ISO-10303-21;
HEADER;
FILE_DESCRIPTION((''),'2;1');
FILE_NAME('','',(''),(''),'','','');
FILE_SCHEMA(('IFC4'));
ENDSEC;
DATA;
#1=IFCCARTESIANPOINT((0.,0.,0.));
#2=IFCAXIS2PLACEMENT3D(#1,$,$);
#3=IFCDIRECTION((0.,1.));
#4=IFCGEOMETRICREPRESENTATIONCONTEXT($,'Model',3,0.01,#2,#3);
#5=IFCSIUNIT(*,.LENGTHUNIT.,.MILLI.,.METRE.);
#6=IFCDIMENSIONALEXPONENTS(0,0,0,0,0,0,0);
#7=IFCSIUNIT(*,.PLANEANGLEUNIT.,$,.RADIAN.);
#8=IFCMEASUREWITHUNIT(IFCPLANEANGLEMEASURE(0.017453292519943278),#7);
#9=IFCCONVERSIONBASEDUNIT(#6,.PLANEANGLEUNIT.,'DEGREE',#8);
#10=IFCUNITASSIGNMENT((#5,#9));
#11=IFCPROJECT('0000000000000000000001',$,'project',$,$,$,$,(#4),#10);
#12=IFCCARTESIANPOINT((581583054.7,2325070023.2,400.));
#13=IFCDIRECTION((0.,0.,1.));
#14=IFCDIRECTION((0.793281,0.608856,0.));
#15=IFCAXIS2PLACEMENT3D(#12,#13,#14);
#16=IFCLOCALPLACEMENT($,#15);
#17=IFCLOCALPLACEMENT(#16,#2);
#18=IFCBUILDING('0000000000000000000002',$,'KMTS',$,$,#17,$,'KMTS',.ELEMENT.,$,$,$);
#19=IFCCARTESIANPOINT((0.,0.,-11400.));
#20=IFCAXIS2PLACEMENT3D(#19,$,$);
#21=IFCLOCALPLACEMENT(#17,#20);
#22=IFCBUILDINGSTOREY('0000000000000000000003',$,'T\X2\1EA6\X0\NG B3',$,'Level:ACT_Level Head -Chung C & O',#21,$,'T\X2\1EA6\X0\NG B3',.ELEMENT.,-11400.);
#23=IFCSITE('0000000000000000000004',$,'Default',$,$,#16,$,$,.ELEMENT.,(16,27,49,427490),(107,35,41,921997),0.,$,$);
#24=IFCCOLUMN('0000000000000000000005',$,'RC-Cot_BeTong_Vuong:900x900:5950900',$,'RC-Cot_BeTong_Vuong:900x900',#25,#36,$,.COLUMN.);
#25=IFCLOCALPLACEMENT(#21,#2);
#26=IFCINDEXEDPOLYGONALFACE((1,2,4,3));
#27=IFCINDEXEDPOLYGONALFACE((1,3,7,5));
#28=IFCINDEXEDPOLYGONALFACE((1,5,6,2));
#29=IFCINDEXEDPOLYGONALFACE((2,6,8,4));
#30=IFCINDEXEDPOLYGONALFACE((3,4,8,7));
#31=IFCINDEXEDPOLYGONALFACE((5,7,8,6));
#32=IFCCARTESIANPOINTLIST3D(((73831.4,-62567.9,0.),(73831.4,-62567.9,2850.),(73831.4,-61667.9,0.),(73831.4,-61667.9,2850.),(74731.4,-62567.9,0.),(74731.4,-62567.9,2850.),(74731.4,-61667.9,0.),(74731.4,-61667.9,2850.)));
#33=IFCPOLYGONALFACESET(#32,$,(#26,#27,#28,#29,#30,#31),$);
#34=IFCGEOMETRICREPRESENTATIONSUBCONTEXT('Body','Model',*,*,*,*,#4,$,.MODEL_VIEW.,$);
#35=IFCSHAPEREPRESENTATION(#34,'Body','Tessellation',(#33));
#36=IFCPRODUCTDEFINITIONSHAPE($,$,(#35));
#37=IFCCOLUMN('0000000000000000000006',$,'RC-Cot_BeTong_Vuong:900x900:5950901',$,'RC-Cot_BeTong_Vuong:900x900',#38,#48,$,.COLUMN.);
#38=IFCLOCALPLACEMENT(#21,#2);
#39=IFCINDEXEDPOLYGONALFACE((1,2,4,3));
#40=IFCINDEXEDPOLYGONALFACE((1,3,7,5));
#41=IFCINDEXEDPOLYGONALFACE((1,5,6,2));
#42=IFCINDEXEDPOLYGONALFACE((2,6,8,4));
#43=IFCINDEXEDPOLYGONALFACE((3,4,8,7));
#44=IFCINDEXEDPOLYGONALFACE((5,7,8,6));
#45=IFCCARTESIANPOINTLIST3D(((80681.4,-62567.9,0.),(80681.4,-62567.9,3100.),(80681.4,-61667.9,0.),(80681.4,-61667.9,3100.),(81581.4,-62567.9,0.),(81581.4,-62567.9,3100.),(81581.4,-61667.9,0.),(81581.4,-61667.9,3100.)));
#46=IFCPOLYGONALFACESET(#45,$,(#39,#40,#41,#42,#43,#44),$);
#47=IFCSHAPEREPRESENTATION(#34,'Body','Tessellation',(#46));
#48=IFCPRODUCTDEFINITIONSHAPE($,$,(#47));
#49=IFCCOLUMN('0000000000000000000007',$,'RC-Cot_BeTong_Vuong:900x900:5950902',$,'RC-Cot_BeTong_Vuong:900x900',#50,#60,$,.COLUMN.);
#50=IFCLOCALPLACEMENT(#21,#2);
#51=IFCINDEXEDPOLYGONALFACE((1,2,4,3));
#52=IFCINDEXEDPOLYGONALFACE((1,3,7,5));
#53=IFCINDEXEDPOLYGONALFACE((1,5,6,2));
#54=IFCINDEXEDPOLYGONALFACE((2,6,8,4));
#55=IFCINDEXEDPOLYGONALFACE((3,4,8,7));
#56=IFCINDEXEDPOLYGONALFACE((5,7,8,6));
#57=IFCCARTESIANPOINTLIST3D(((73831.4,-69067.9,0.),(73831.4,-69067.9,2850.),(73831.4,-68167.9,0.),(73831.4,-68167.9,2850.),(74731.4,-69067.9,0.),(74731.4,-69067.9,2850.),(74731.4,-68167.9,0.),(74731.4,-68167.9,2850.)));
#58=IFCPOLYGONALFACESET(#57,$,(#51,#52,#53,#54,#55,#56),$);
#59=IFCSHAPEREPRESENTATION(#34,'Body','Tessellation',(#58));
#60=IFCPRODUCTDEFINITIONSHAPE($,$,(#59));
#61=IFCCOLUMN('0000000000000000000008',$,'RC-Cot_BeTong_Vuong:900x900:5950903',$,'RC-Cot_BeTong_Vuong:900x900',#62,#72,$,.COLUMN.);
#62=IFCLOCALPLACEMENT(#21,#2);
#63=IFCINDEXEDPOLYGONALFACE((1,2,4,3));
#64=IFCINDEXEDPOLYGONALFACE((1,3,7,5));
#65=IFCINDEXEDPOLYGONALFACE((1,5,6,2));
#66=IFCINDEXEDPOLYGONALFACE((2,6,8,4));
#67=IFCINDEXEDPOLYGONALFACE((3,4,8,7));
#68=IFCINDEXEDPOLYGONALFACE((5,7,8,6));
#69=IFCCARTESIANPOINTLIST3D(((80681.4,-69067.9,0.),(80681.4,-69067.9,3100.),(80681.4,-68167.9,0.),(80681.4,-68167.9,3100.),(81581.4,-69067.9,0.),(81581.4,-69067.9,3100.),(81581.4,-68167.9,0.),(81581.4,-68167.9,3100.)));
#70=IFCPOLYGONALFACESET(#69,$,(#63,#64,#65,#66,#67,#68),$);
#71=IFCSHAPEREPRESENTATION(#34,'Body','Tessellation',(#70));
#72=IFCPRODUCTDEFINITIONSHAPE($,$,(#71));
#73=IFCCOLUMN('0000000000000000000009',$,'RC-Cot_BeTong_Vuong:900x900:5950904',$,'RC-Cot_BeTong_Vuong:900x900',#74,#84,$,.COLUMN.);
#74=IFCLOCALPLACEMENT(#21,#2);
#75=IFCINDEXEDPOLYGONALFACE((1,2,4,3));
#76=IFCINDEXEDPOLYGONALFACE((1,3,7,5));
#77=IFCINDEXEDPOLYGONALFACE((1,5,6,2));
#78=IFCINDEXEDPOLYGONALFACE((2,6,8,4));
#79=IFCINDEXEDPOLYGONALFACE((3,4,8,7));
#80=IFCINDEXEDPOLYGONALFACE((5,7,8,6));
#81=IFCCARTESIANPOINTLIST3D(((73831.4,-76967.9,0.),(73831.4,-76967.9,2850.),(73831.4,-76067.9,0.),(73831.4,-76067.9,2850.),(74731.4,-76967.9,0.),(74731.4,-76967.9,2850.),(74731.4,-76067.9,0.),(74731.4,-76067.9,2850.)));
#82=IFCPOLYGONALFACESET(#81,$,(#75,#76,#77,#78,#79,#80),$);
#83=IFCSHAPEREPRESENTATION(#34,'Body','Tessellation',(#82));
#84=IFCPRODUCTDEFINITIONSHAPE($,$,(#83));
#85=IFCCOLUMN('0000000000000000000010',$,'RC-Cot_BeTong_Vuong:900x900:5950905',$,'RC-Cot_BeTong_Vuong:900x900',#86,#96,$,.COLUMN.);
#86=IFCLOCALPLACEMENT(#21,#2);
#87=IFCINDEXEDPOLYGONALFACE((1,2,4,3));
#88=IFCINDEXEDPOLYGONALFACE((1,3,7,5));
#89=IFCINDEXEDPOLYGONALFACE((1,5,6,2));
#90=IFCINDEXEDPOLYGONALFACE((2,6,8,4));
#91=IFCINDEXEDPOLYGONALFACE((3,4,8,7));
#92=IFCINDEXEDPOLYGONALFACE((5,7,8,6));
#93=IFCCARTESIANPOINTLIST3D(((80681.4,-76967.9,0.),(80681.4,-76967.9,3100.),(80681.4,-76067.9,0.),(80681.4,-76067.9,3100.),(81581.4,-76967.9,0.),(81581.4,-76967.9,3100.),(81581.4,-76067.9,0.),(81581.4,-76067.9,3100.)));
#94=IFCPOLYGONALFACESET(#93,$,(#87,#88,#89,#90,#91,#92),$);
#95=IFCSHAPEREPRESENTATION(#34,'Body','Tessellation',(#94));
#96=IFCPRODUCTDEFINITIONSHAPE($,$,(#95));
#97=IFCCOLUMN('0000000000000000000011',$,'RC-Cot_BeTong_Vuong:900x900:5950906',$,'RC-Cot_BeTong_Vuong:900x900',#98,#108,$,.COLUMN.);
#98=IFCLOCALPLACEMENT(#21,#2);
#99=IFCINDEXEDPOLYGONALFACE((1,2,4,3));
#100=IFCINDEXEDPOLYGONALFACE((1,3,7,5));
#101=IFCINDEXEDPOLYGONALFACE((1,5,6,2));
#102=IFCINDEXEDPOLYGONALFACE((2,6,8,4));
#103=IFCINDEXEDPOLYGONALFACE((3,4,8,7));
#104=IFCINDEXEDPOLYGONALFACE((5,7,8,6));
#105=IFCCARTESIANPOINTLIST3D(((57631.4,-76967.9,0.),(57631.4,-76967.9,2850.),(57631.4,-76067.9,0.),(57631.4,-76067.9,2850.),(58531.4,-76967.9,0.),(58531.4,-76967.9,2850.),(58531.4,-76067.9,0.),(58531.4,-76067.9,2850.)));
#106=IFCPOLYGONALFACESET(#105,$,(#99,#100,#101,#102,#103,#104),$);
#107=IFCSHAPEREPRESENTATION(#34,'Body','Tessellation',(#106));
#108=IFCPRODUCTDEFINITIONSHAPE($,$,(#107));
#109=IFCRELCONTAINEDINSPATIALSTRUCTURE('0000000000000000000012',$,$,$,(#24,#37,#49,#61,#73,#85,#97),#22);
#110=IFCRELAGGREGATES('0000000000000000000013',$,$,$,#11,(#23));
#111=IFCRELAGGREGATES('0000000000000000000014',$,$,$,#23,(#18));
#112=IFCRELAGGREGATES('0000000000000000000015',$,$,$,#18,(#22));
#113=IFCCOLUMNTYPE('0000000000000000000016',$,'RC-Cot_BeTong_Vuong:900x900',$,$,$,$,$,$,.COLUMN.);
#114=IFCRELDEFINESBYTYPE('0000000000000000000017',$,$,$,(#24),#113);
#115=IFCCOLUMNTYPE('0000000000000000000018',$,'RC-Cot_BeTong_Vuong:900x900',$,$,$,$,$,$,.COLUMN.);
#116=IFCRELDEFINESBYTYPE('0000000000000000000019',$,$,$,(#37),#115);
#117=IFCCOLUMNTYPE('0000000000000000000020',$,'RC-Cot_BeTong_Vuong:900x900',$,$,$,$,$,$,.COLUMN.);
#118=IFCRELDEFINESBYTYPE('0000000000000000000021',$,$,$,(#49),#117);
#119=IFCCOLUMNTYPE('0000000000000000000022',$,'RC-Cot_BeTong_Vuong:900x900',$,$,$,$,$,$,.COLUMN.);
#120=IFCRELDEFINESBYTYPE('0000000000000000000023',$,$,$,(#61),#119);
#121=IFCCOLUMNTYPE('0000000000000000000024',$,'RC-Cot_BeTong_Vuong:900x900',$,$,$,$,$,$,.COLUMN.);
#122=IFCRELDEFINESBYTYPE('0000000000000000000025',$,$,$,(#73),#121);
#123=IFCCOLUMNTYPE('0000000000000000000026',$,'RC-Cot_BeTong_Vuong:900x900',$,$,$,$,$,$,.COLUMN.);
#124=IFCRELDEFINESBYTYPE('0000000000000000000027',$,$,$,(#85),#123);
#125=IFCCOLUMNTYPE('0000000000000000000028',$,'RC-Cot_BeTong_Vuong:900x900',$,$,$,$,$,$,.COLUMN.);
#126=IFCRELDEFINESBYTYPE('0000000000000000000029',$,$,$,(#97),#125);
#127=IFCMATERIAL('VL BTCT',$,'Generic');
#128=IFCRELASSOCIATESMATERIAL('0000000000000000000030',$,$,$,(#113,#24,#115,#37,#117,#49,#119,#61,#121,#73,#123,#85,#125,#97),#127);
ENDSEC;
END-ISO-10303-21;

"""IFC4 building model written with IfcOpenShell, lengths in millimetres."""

from ifc_helpers import new_model, entity, si_unit, converted_unit, direction, frame, origin, place, context, subcontext, project, spatial, indexed_curve, outline, extrude, source, transform, mapped, material, type_object, type_shapes, element, save


model = new_model("IFC4")

# Units and contexts
model_context = context("Model", 3, precision=0.01, world=origin(), true_north=direction((0.0, 1.0)))
body_context = subcontext(model_context, "Body", "Model", "MODEL_VIEW")
ifc_project = project(units=[si_unit("LENGTHUNIT", "METRE", prefix="MILLI"), converted_unit("PLANEANGLEUNIT", "DEGREE", entity("IfcPlaneAngleMeasure", 0.017453292519943278), si_unit("PLANEANGLEUNIT", "RADIAN"), dimensions=[0, 0, 0, 0, 0, 0, 0])], contexts=[model_context])

# Site, building, storey
site_placement = place(None, frame((581583054.7, 2325070023.2, 400.0), z_axis=(0.0, 0.0, 1.0), x_axis=(0.793281, 0.608856, 0.0)))
site = spatial("IfcSite", under=ifc_project, at=site_placement, Name="Default", CompositionType="ELEMENT", RefLatitude=(16, 27, 49, 427490), RefLongitude=(107, 35, 41, 921997), RefElevation=0.0)
building_placement = place(site_placement, origin())
building = spatial("IfcBuilding", under=site, at=building_placement, Name="KMTS", LongName="KMTS", CompositionType="ELEMENT")
storey_placement = place(building_placement, frame((0.0, 0.0, -11400.0)))
storey = spatial("IfcBuildingStorey", under=building, at=storey_placement, Name="TẦNG B3", ObjectType="Level:ACT_Level Head -Chung C & O", LongName="TẦNG B3", CompositionType="ELEMENT", Elevation=-11400.0)

# Columns
ifc_material = material(Name="VL BTCT", Category="Generic")
column_type_1 = type_object("IfcColumnType", Name="RC-Cot_BeTong_Vuong:900x900", PredefinedType="COLUMN", material=ifc_material)
shared_shape_1 = source(origin(), body_context, "Body", "SweptSolid", [
    extrude(outline(indexed_curve([(-450.0, -450.0), (450.0, -450.0), (450.0, 450.0), (-450.0, 450.0), (-450.0, -450.0)], self_intersect=False)), frame((74281.4, -62117.9, -11400.0), z_axis=(0.0, 0.0, 1.0), x_axis=(-1.0, 0.0, 0.0)), (0.0, 0.0, 1.0), 2850.0),
])
type_shapes(column_type_1, [shared_shape_1])
column_1_placement = place(storey_placement, frame((0.0, 0.0, 11400.0)))
element("IfcColumn", 1, at=column_1_placement, inside=storey, type_object=column_type_1, material=ifc_material, Name="RC-Cot_BeTong_Vuong:900x900:5950900", ObjectType="RC-Cot_BeTong_Vuong:900x900", PredefinedType="COLUMN", context=body_context, shape_type="MappedRepresentation", body=[
    mapped(shared_shape_1, transform((0.0, 0.0, 0.0), scale=1.0)),
])
column_type_2 = type_object("IfcColumnType", Name="RC-Cot_BeTong_Vuong:900x900", PredefinedType="COLUMN", material=ifc_material)
shared_shape_2 = source(origin(), body_context, "Body", "SweptSolid", [
    extrude(outline(indexed_curve([(-450.0, -450.0), (450.0, -450.0), (450.0, 450.0), (-450.0, 450.0), (-450.0, -450.0)], self_intersect=False)), frame((81131.4, -62117.9, -11400.0), z_axis=(0.0, 0.0, 1.0), x_axis=(-1.0, 0.0, 0.0)), (0.0, 0.0, 1.0), 3100.0),
])
type_shapes(column_type_2, [shared_shape_2])
column_2_placement = place(storey_placement, frame((0.0, 0.0, 11400.0)))
element("IfcColumn", 2, at=column_2_placement, inside=storey, type_object=column_type_2, material=ifc_material, Name="RC-Cot_BeTong_Vuong:900x900:5950901", ObjectType="RC-Cot_BeTong_Vuong:900x900", PredefinedType="COLUMN", context=body_context, shape_type="MappedRepresentation", body=[
    mapped(shared_shape_2, transform((0.0, 0.0, 0.0), scale=1.0)),
])
column_type_3 = type_object("IfcColumnType", Name="RC-Cot_BeTong_Vuong:900x900", PredefinedType="COLUMN", material=ifc_material)
shared_shape_3 = source(origin(), body_context, "Body", "SweptSolid", [
    extrude(outline(indexed_curve([(-450.0, -450.0), (450.0, -450.0), (450.0, 450.0), (-450.0, 450.0), (-450.0, -450.0)], self_intersect=False)), frame((74281.4, -68617.9, -11400.0), z_axis=(0.0, 0.0, 1.0), x_axis=(-1.0, 0.0, 0.0)), (0.0, 0.0, 1.0), 2850.0),
])
type_shapes(column_type_3, [shared_shape_3])
column_3_placement = place(storey_placement, frame((0.0, 0.0, 11400.0)))
element("IfcColumn", 3, at=column_3_placement, inside=storey, type_object=column_type_3, material=ifc_material, Name="RC-Cot_BeTong_Vuong:900x900:5950902", ObjectType="RC-Cot_BeTong_Vuong:900x900", PredefinedType="COLUMN", context=body_context, shape_type="MappedRepresentation", body=[
    mapped(shared_shape_3, transform((0.0, 0.0, 0.0), scale=1.0)),
])
column_type_4 = type_object("IfcColumnType", Name="RC-Cot_BeTong_Vuong:900x900", PredefinedType="COLUMN", material=ifc_material)
shared_shape_4 = source(origin(), body_context, "Body", "SweptSolid", [
    extrude(outline(indexed_curve([(-450.0, -450.0), (450.0, -450.0), (450.0, 450.0), (-450.0, 450.0), (-450.0, -450.0)], self_intersect=False)), frame((81131.4, -68617.9, -11400.0), z_axis=(0.0, 0.0, 1.0), x_axis=(-1.0, 0.0, 0.0)), (0.0, 0.0, 1.0), 3100.0),
])
type_shapes(column_type_4, [shared_shape_4])
column_4_placement = place(storey_placement, frame((0.0, 0.0, 11400.0)))
element("IfcColumn", 4, at=column_4_placement, inside=storey, type_object=column_type_4, material=ifc_material, Name="RC-Cot_BeTong_Vuong:900x900:5950903", ObjectType="RC-Cot_BeTong_Vuong:900x900", PredefinedType="COLUMN", context=body_context, shape_type="MappedRepresentation", body=[
    mapped(shared_shape_4, transform((0.0, 0.0, 0.0), scale=1.0)),
])
column_type_5 = type_object("IfcColumnType", Name="RC-Cot_BeTong_Vuong:900x900", PredefinedType="COLUMN", material=ifc_material)
shared_shape_5 = source(origin(), body_context, "Body", "SweptSolid", [
    extrude(outline(indexed_curve([(-450.0, -450.0), (450.0, -450.0), (450.0, 450.0), (-450.0, 450.0), (-450.0, -450.0)], self_intersect=False)), frame((74281.4, -76517.9, -11400.0), z_axis=(0.0, 0.0, 1.0), x_axis=(-1.0, 0.0, 0.0)), (0.0, 0.0, 1.0), 2850.0),
])
type_shapes(column_type_5, [shared_shape_5])
column_5_placement = place(storey_placement, frame((0.0, 0.0, 11400.0)))
element("IfcColumn", 5, at=column_5_placement, inside=storey, type_object=column_type_5, material=ifc_material, Name="RC-Cot_BeTong_Vuong:900x900:5950904", ObjectType="RC-Cot_BeTong_Vuong:900x900", PredefinedType="COLUMN", context=body_context, shape_type="MappedRepresentation", body=[
    mapped(shared_shape_5, transform((0.0, 0.0, 0.0), scale=1.0)),
])
column_type_6 = type_object("IfcColumnType", Name="RC-Cot_BeTong_Vuong:900x900", PredefinedType="COLUMN", material=ifc_material)
shared_shape_6 = source(origin(), body_context, "Body", "SweptSolid", [
    extrude(outline(indexed_curve([(-450.0, -450.0), (450.0, -450.0), (450.0, 450.0), (-450.0, 450.0), (-450.0, -450.0)], self_intersect=False)), frame((81131.4, -76517.9, -11400.0), z_axis=(0.0, 0.0, 1.0), x_axis=(-1.0, 0.0, 0.0)), (0.0, 0.0, 1.0), 3100.0),
])
type_shapes(column_type_6, [shared_shape_6])
column_6_placement = place(storey_placement, frame((0.0, 0.0, 11400.0)))
element("IfcColumn", 6, at=column_6_placement, inside=storey, type_object=column_type_6, material=ifc_material, Name="RC-Cot_BeTong_Vuong:900x900:5950905", ObjectType="RC-Cot_BeTong_Vuong:900x900", PredefinedType="COLUMN", context=body_context, shape_type="MappedRepresentation", body=[
    mapped(shared_shape_6, transform((0.0, 0.0, 0.0), scale=1.0)),
])
column_type_7 = type_object("IfcColumnType", Name="RC-Cot_BeTong_Vuong:900x900", PredefinedType="COLUMN", material=ifc_material)
shared_shape_7 = source(origin(), body_context, "Body", "SweptSolid", [
    extrude(outline(indexed_curve([(-450.0, -450.0), (450.0, -450.0), (450.0, 450.0), (-450.0, 450.0), (-450.0, -450.0)], self_intersect=False)), frame((58081.4, -76517.9, -11400.0), z_axis=(0.0, 0.0, 1.0), x_axis=(-1.0, 0.0, 0.0)), (0.0, 0.0, 1.0), 2850.0),
])
type_shapes(column_type_7, [shared_shape_7])
column_7_placement = place(storey_placement, frame((0.0, 0.0, 11400.0)))
element("IfcColumn", 7, at=column_7_placement, inside=storey, type_object=column_type_7, material=ifc_material, Name="RC-Cot_BeTong_Vuong:900x900:5950906", ObjectType="RC-Cot_BeTong_Vuong:900x900", PredefinedType="COLUMN", context=body_context, shape_type="MappedRepresentation", body=[
    mapped(shared_shape_7, transform((0.0, 0.0, 0.0), scale=1.0)),
])

save(model, "model.ifc")
